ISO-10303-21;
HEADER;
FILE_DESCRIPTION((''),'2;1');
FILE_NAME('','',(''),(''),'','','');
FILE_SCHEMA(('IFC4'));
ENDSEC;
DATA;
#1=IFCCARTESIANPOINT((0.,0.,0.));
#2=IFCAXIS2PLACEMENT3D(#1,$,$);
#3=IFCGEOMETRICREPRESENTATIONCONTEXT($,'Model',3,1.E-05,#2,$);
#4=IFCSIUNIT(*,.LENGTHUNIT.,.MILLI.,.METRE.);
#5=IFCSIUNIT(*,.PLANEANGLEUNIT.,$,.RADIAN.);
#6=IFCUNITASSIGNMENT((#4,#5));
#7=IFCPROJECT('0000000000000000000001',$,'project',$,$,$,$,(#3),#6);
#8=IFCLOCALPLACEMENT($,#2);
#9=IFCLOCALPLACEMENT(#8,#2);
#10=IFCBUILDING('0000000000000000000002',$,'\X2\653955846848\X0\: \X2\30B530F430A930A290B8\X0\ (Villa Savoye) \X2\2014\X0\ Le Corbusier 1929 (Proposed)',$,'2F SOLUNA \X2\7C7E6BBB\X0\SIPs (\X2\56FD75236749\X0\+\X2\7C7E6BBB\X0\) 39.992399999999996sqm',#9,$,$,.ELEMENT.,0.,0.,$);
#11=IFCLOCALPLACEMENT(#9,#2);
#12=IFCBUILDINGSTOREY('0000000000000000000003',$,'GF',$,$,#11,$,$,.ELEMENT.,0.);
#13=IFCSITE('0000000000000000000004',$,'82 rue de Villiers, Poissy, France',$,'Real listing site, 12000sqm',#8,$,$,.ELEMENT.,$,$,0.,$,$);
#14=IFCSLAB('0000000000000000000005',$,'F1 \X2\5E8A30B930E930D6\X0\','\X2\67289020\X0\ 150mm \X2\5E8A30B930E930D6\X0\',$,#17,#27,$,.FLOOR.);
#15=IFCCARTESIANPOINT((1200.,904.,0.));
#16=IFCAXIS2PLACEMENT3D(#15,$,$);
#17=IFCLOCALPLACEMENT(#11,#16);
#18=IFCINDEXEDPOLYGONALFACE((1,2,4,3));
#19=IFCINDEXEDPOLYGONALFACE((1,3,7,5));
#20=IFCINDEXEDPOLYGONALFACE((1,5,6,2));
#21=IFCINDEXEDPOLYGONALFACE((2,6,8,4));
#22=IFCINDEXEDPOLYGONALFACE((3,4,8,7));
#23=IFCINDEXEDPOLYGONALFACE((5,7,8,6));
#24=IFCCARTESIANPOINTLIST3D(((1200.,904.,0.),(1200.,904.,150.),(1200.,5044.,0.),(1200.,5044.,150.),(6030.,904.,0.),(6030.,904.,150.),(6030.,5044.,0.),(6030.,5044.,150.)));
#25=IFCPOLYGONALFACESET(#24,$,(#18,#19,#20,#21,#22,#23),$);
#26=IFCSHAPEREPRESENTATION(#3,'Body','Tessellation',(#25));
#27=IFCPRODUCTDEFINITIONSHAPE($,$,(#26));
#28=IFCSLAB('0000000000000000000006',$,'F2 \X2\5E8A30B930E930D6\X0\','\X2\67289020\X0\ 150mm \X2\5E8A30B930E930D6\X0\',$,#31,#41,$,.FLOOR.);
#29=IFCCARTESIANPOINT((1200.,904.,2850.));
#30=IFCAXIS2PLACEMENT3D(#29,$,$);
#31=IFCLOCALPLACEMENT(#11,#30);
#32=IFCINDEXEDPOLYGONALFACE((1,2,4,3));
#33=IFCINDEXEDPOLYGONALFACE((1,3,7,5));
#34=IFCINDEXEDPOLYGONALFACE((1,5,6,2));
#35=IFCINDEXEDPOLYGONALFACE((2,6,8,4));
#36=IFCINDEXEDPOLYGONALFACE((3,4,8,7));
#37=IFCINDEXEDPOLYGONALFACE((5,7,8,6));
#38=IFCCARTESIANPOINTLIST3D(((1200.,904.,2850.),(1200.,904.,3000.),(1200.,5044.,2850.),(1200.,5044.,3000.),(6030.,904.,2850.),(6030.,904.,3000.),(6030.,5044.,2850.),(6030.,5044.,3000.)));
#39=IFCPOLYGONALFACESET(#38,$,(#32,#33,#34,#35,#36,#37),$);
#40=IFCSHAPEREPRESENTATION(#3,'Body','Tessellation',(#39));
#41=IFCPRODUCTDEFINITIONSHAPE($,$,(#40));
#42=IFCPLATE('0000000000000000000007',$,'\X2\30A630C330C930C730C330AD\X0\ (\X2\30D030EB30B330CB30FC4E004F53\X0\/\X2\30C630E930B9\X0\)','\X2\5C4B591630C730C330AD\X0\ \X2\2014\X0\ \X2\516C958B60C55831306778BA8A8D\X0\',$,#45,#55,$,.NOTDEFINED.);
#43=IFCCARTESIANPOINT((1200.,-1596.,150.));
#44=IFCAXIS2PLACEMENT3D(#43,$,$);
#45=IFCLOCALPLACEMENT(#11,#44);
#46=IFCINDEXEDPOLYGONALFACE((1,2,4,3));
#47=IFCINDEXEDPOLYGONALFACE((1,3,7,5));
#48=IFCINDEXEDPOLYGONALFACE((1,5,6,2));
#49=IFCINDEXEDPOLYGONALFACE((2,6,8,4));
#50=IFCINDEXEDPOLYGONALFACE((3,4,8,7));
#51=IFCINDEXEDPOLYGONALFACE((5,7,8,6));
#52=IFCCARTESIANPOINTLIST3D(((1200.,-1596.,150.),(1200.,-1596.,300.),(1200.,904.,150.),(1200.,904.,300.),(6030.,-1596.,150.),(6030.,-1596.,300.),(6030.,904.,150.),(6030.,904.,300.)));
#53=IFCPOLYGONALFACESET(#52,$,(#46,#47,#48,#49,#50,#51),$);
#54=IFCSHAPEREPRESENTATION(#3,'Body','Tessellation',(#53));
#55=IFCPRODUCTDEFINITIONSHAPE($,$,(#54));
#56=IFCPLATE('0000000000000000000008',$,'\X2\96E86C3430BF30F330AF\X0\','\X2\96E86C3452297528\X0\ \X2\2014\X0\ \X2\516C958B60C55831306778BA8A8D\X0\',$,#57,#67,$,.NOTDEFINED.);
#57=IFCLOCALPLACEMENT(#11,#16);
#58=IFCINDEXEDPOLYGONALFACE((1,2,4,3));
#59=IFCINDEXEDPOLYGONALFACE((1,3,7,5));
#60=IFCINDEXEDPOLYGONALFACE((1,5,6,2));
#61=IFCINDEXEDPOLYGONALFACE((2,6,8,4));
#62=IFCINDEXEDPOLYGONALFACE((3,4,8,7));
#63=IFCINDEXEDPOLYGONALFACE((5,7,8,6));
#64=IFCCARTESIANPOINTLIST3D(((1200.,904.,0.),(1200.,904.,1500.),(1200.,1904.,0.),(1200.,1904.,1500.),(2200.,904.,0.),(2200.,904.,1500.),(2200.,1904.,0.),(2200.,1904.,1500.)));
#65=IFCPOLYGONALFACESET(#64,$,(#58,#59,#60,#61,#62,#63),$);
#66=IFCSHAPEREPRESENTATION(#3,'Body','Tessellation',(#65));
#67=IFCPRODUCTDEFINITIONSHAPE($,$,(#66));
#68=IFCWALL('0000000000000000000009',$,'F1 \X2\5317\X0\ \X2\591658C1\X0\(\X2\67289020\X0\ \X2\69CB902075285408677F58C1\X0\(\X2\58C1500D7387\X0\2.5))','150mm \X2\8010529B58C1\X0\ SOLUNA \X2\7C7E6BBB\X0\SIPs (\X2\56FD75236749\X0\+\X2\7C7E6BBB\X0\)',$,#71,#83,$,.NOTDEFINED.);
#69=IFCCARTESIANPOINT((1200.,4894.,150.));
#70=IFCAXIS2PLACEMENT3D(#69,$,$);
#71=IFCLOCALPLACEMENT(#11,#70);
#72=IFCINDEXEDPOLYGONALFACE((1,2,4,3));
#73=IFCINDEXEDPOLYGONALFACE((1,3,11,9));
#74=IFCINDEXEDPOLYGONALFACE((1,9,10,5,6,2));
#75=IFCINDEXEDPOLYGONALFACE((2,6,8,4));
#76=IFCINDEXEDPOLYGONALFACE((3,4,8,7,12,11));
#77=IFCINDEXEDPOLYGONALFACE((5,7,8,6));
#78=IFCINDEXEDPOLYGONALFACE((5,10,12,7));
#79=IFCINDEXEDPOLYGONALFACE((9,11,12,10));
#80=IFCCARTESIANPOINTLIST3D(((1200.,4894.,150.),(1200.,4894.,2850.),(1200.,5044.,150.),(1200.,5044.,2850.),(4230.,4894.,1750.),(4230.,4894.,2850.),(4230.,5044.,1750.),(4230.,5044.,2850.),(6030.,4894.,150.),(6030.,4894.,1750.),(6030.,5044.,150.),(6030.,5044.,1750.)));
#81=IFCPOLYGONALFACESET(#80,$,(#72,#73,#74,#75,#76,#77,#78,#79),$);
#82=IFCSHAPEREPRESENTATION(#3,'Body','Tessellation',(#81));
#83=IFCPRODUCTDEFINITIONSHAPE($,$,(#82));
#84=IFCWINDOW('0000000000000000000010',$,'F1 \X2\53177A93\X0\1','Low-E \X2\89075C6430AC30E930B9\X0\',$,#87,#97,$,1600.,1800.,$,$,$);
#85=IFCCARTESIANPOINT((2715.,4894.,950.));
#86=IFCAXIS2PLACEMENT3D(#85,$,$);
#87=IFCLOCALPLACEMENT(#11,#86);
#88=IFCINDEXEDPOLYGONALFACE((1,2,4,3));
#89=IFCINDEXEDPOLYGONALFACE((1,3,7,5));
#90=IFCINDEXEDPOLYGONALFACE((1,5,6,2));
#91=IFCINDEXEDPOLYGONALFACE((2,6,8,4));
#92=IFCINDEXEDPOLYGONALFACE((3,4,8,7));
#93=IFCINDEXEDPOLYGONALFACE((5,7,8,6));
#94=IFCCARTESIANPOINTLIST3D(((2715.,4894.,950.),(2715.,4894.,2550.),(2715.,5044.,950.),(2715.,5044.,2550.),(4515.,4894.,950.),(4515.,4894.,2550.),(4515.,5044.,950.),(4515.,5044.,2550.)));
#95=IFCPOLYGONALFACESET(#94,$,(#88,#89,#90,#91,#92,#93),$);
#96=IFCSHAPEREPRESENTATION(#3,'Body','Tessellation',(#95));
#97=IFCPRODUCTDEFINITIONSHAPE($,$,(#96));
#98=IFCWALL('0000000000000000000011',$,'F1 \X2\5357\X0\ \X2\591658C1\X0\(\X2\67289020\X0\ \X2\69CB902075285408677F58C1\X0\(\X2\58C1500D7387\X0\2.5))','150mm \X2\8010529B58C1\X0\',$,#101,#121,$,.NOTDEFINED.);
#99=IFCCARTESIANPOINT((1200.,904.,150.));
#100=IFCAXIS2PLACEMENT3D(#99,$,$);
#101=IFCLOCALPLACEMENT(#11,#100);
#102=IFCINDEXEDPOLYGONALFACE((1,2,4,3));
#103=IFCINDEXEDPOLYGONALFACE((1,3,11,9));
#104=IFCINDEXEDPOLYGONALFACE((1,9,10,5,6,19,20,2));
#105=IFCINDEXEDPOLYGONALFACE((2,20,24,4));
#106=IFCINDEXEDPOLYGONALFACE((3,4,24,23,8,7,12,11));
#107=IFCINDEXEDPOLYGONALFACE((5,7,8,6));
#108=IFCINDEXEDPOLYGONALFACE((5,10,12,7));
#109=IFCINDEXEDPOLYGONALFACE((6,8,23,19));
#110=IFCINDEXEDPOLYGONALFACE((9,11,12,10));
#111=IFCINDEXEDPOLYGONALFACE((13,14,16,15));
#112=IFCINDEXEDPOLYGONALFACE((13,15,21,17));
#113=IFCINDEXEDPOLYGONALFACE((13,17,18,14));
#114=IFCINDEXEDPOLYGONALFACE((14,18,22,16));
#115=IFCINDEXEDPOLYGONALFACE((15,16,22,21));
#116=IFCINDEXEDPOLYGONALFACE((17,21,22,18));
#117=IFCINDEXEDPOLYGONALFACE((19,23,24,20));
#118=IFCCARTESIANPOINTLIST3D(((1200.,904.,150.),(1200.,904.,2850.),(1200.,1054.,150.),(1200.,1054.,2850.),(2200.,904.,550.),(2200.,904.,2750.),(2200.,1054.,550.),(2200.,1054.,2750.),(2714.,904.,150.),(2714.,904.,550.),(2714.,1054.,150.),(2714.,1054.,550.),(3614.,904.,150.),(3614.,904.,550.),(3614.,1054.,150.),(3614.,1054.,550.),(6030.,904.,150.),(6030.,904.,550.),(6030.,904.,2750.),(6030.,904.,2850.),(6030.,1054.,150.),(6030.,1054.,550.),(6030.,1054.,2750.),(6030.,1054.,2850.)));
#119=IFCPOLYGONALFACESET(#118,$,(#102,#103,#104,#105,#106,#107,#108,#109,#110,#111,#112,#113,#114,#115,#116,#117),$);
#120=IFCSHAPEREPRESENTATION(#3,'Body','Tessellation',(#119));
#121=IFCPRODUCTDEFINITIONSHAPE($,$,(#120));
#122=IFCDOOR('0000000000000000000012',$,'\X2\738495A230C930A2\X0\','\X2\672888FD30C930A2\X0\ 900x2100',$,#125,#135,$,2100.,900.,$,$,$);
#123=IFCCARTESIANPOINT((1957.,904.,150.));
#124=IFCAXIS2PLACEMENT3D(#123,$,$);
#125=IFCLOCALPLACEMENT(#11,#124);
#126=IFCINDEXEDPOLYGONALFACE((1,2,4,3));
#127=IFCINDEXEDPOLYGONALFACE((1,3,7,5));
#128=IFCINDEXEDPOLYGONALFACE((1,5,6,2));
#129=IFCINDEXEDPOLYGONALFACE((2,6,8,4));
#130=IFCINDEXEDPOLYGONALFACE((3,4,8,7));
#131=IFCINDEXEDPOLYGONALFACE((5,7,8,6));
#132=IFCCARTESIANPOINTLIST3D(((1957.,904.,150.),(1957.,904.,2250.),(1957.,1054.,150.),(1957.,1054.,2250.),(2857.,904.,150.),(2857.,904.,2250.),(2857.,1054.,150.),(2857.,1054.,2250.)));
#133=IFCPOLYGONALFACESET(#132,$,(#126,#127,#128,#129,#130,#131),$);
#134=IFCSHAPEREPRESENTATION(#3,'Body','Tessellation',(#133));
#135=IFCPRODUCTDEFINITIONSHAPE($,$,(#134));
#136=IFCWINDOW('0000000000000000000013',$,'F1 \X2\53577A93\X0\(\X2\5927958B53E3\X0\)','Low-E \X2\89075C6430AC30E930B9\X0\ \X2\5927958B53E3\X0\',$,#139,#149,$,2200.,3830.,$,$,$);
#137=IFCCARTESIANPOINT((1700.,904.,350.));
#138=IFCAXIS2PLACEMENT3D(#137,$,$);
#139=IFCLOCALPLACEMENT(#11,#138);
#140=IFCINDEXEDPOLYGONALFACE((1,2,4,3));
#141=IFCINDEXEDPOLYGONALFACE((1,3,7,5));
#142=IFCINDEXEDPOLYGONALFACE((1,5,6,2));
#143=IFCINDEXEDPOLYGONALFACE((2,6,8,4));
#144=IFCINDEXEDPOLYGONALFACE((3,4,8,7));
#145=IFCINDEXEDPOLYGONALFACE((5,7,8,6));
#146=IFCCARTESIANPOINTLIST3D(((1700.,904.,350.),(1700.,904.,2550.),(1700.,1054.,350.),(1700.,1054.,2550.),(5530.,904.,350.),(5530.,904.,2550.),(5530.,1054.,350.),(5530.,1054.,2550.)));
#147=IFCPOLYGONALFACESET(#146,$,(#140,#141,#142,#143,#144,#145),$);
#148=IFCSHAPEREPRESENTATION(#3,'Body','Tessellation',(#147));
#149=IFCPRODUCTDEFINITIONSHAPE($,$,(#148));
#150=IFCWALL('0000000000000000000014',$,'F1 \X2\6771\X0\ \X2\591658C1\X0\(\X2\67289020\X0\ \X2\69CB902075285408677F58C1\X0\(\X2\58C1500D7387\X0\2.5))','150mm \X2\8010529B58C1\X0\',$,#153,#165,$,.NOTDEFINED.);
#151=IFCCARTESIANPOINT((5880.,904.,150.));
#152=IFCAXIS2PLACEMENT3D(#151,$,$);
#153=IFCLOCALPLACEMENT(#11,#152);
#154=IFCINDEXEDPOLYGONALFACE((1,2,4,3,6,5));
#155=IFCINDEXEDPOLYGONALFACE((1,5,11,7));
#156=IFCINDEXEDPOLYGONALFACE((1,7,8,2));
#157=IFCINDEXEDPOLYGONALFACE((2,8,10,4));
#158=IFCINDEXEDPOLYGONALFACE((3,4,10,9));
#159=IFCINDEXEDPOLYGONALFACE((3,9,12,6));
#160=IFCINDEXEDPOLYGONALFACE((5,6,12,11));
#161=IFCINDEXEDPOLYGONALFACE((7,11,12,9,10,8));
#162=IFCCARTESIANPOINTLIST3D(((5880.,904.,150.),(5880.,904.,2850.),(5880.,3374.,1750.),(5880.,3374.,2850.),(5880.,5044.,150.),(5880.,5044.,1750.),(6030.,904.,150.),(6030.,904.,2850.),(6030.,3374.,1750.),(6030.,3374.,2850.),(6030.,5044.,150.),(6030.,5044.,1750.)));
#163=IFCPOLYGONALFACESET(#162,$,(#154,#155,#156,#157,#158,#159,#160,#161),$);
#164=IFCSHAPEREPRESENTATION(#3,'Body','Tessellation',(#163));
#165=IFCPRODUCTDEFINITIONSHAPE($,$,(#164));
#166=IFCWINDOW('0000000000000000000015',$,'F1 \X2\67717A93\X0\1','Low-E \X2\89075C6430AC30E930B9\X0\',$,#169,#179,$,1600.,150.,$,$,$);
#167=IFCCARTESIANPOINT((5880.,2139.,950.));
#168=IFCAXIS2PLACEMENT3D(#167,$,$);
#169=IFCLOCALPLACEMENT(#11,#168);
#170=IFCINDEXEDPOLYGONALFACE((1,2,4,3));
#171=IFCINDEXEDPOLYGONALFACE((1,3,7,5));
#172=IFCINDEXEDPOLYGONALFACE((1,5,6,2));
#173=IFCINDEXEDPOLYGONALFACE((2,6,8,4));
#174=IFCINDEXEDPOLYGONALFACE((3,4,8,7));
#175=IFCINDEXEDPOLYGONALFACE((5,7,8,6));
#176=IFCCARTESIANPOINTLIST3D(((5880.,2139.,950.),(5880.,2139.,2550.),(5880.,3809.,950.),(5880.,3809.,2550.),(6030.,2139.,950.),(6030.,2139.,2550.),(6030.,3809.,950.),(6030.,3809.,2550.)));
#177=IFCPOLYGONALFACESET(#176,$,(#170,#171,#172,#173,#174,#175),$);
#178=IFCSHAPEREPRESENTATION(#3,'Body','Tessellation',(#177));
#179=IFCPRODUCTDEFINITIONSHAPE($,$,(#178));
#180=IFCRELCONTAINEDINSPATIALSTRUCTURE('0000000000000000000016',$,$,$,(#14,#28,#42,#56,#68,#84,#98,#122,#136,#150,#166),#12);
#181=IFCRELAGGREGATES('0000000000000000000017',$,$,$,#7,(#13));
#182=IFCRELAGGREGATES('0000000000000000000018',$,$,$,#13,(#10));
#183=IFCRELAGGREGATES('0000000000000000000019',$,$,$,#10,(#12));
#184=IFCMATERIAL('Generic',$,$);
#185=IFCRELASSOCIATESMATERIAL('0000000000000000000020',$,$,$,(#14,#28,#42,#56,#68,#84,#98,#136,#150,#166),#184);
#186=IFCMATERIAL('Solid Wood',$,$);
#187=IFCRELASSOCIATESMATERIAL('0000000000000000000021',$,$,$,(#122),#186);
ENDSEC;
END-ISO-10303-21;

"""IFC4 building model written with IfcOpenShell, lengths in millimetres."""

from ifc_helpers import new_model, si_unit, frame, frame_2d, origin, place, context, project, spatial, rectangle, extrude, material, element, fill, save


model = new_model("IFC4")

# Units and contexts
model_context = context("Model", 3, precision=1e-05, world=origin())
ifc_project = project(units=[si_unit("LENGTHUNIT", "METRE", prefix="MILLI"), si_unit("PLANEANGLEUNIT", "RADIAN")], contexts=[model_context])

# Site, building, storey
site_placement = place(None, origin())
site = spatial("IfcSite", under=ifc_project, at=site_placement, Name="82 rue de Villiers, Poissy, France", ObjectType="Real listing site, 12000sqm", CompositionType="ELEMENT", RefElevation=0.0)
building_placement = place(site_placement, origin())
building = spatial("IfcBuilding", under=site, at=building_placement, Name="改善案: サヴォア邸 (Villa Savoye) — Le Corbusier 1929 (Proposed)", ObjectType="2F SOLUNA 籾殻SIPs (国産杉+籾殻) 39.992399999999996sqm", CompositionType="ELEMENT", ElevationOfRefHeight=0.0, ElevationOfTerrain=0.0)
storey_placement = place(building_placement, origin())
storey = spatial("IfcBuildingStorey", under=building, at=storey_placement, Name="GF", CompositionType="ELEMENT", Elevation=0.0)

# Slabs
ifc_material_1 = material(Name="Generic")
slab_1_placement = place(storey_placement, frame((1200.0, 904.0, 0.0)))
element("IfcSlab", 1, at=slab_1_placement, inside=storey, material=ifc_material_1, Name="F1 床スラブ", Description="木造 150mm 床スラブ", PredefinedType="FLOOR", context=model_context, shape_type="SweptSolid", body=[
    extrude(rectangle(XDim=4830.0, YDim=4140.0, at=frame_2d((2415.0, 2070.0))), frame((1200.0, 904.0, 0.0)), (0.0, 0.0, 1.0), 150.0),
])
slab_2_placement = place(storey_placement, frame((1200.0, 904.0, 2850.0)))
element("IfcSlab", 2, at=slab_2_placement, inside=storey, material=ifc_material_1, Name="F2 床スラブ", Description="木造 150mm 床スラブ", PredefinedType="FLOOR", context=model_context, shape_type="SweptSolid", body=[
    extrude(rectangle(XDim=4830.0, YDim=4140.0, at=frame_2d((2415.0, 2070.0))), frame((1200.0, 904.0, 2850.0)), (0.0, 0.0, 1.0), 150.0),
])

# Plates
plate_1_placement = place(storey_placement, frame((1200.0, -1596.0, 150.0)))
element("IfcPlate", 3, at=plate_1_placement, inside=storey, material=ifc_material_1, Name="ウッドデッキ (バルコニー一体/テラス)", Description="屋外デッキ — 公開情報で確認", PredefinedType="NOTDEFINED", context=model_context, shape_type="SweptSolid", body=[
    extrude(rectangle(XDim=4830.0, YDim=2500.0, at=frame_2d((2415.0, 1250.0))), frame((1200.0, -1596.0, 150.0)), (0.0, 0.0, 1.0), 150.0),
])
plate_2_placement = place(storey_placement, frame((1200.0, 904.0, 0.0)))
element("IfcPlate", 4, at=plate_2_placement, inside=storey, material=ifc_material_1, Name="雨水タンク", Description="雨水利用 — 公開情報で確認", PredefinedType="NOTDEFINED", context=model_context, shape_type="SweptSolid", body=[
    extrude(rectangle(XDim=1000.0, YDim=1000.0, at=frame_2d((500.0, 500.0))), frame((1200.0, 904.0, 0.0)), (0.0, 0.0, 1.0), 1500.0),
])

# Wall, opening, window
wall_1_placement = place(storey_placement, frame((1200.0, 4894.0, 150.0)))
wall_1 = element("IfcWall", 5, at=wall_1_placement, inside=storey, material=ifc_material_1, Name="F1 北 外壁(木造 構造用合板壁(壁倍率2.5))", Description="150mm 耐力壁 SOLUNA 籾殻SIPs (国産杉+籾殻)", PredefinedType="NOTDEFINED", context=model_context, shape_type="SweptSolid", body=[
    extrude(rectangle(XDim=4830.0, YDim=150.0, at=frame_2d((2415.0, 75.0))), frame((1200.0, 4894.0, 150.0)), (0.0, 0.0, 1.0), 2700.0),
])
opening_1_placement = place(storey_placement, frame((2715.0, 4894.0, 950.0)))
opening_1 = element("IfcOpeningElement", 6, at=opening_1_placement, cuts=wall_1, PredefinedType="NOTDEFINED", context=model_context, shape_type="SweptSolid", body=[
    extrude(rectangle(XDim=1800.0, YDim=150.0, at=frame_2d((900.0, 75.0))), frame((2715.0, 4894.0, 950.0)), (0.0, 0.0, 1.0), 1600.0),
])
window_1_placement = place(storey_placement, frame((2715.0, 4894.0, 950.0)))
window_1 = element("IfcWindow", 7, at=window_1_placement, inside=storey, material=ifc_material_1, Name="F1 北窓1", Description="Low-E 複層ガラス", OverallHeight=1600.0, OverallWidth=1800.0, context=model_context, shape_type="SweptSolid", body=[
    extrude(rectangle(XDim=1800.0, YDim=150.0, at=frame_2d((900.0, 75.0))), frame((2715.0, 4894.0, 950.0)), (0.0, 0.0, 1.0), 1600.0),
])
fill(opening_1, window_1)

# Wall, openings, door, window
wall_2_placement = place(storey_placement, frame((1200.0, 904.0, 150.0)))
wall_2 = element("IfcWall", 8, at=wall_2_placement, inside=storey, material=ifc_material_1, Name="F1 南 外壁(木造 構造用合板壁(壁倍率2.5))", Description="150mm 耐力壁", PredefinedType="NOTDEFINED", context=model_context, shape_type="SweptSolid", body=[
    extrude(rectangle(XDim=4830.0, YDim=150.0, at=frame_2d((2415.0, 75.0))), frame((1200.0, 904.0, 150.0)), (0.0, 0.0, 1.0), 2700.0),
])
opening_2_placement = place(storey_placement, frame((1957.0, 904.0, 150.0)))
opening_2 = element("IfcOpeningElement", 9, at=opening_2_placement, cuts=wall_2, PredefinedType="NOTDEFINED", context=model_context, shape_type="SweptSolid", body=[
    extrude(rectangle(XDim=900.0, YDim=150.0, at=frame_2d((450.0, 75.0))), frame((1957.0, 904.0, 150.0)), (0.0, 0.0, 1.0), 2100.0),
])
opening_3_placement = place(storey_placement, frame((1700.0, 904.0, 350.0)))
opening_3 = element("IfcOpeningElement", 10, at=opening_3_placement, cuts=wall_2, PredefinedType="NOTDEFINED", context=model_context, shape_type="SweptSolid", body=[
    extrude(rectangle(XDim=3830.0, YDim=150.0, at=frame_2d((1915.0, 75.0))), frame((1700.0, 904.0, 350.0)), (0.0, 0.0, 1.0), 2200.0),
])
ifc_material_2 = material(Name="Solid Wood")
door_placement = place(storey_placement, frame((1957.0, 904.0, 150.0)))
door = element("IfcDoor", 11, at=door_placement, inside=storey, material=ifc_material_2, Name="玄関ドア", Description="木製ドア 900x2100", OverallHeight=2100.0, OverallWidth=900.0, context=model_context, shape_type="SweptSolid", body=[
    extrude(rectangle(XDim=900.0, YDim=150.0, at=frame_2d((450.0, 75.0))), frame((1957.0, 904.0, 150.0)), (0.0, 0.0, 1.0), 2100.0),
])
fill(opening_2, door)
window_2_placement = place(storey_placement, frame((1700.0, 904.0, 350.0)))
window_2 = element("IfcWindow", 12, at=window_2_placement, inside=storey, material=ifc_material_1, Name="F1 南窓(大開口)", Description="Low-E 複層ガラス 大開口", OverallHeight=2200.0, OverallWidth=3830.0, context=model_context, shape_type="SweptSolid", body=[
    extrude(rectangle(XDim=3830.0, YDim=150.0, at=frame_2d((1915.0, 75.0))), frame((1700.0, 904.0, 350.0)), (0.0, 0.0, 1.0), 2200.0),
])
fill(opening_3, window_2)

# Wall, opening, window
wall_3_placement = place(storey_placement, frame((5880.0, 904.0, 150.0)))
wall_3 = element("IfcWall", 13, at=wall_3_placement, inside=storey, material=ifc_material_1, Name="F1 東 外壁(木造 構造用合板壁(壁倍率2.5))", Description="150mm 耐力壁", PredefinedType="NOTDEFINED", context=model_context, shape_type="SweptSolid", body=[
    extrude(rectangle(XDim=150.0, YDim=4140.0, at=frame_2d((75.0, 2070.0))), frame((5880.0, 904.0, 150.0)), (0.0, 0.0, 1.0), 2700.0),
])
opening_4_placement = place(storey_placement, frame((5880.0, 2139.0, 950.0)))
opening_4 = element("IfcOpeningElement", 14, at=opening_4_placement, cuts=wall_3, PredefinedType="NOTDEFINED", context=model_context, shape_type="SweptSolid", body=[
    extrude(rectangle(XDim=150.0, YDim=1670.0, at=frame_2d((75.0, 835.0))), frame((5880.0, 2139.0, 950.0)), (0.0, 0.0, 1.0), 1600.0),
])
window_3_placement = place(storey_placement, frame((5880.0, 2139.0, 950.0)))
window_3 = element("IfcWindow", 15, at=window_3_placement, inside=storey, material=ifc_material_1, Name="F1 東窓1", Description="Low-E 複層ガラス", OverallHeight=1600.0, OverallWidth=150.0, context=model_context, shape_type="SweptSolid", body=[
    extrude(rectangle(XDim=150.0, YDim=1670.0, at=frame_2d((75.0, 835.0))), frame((5880.0, 2139.0, 950.0)), (0.0, 0.0, 1.0), 1600.0),
])
fill(opening_4, window_3)

save(model, "model.ifc")
